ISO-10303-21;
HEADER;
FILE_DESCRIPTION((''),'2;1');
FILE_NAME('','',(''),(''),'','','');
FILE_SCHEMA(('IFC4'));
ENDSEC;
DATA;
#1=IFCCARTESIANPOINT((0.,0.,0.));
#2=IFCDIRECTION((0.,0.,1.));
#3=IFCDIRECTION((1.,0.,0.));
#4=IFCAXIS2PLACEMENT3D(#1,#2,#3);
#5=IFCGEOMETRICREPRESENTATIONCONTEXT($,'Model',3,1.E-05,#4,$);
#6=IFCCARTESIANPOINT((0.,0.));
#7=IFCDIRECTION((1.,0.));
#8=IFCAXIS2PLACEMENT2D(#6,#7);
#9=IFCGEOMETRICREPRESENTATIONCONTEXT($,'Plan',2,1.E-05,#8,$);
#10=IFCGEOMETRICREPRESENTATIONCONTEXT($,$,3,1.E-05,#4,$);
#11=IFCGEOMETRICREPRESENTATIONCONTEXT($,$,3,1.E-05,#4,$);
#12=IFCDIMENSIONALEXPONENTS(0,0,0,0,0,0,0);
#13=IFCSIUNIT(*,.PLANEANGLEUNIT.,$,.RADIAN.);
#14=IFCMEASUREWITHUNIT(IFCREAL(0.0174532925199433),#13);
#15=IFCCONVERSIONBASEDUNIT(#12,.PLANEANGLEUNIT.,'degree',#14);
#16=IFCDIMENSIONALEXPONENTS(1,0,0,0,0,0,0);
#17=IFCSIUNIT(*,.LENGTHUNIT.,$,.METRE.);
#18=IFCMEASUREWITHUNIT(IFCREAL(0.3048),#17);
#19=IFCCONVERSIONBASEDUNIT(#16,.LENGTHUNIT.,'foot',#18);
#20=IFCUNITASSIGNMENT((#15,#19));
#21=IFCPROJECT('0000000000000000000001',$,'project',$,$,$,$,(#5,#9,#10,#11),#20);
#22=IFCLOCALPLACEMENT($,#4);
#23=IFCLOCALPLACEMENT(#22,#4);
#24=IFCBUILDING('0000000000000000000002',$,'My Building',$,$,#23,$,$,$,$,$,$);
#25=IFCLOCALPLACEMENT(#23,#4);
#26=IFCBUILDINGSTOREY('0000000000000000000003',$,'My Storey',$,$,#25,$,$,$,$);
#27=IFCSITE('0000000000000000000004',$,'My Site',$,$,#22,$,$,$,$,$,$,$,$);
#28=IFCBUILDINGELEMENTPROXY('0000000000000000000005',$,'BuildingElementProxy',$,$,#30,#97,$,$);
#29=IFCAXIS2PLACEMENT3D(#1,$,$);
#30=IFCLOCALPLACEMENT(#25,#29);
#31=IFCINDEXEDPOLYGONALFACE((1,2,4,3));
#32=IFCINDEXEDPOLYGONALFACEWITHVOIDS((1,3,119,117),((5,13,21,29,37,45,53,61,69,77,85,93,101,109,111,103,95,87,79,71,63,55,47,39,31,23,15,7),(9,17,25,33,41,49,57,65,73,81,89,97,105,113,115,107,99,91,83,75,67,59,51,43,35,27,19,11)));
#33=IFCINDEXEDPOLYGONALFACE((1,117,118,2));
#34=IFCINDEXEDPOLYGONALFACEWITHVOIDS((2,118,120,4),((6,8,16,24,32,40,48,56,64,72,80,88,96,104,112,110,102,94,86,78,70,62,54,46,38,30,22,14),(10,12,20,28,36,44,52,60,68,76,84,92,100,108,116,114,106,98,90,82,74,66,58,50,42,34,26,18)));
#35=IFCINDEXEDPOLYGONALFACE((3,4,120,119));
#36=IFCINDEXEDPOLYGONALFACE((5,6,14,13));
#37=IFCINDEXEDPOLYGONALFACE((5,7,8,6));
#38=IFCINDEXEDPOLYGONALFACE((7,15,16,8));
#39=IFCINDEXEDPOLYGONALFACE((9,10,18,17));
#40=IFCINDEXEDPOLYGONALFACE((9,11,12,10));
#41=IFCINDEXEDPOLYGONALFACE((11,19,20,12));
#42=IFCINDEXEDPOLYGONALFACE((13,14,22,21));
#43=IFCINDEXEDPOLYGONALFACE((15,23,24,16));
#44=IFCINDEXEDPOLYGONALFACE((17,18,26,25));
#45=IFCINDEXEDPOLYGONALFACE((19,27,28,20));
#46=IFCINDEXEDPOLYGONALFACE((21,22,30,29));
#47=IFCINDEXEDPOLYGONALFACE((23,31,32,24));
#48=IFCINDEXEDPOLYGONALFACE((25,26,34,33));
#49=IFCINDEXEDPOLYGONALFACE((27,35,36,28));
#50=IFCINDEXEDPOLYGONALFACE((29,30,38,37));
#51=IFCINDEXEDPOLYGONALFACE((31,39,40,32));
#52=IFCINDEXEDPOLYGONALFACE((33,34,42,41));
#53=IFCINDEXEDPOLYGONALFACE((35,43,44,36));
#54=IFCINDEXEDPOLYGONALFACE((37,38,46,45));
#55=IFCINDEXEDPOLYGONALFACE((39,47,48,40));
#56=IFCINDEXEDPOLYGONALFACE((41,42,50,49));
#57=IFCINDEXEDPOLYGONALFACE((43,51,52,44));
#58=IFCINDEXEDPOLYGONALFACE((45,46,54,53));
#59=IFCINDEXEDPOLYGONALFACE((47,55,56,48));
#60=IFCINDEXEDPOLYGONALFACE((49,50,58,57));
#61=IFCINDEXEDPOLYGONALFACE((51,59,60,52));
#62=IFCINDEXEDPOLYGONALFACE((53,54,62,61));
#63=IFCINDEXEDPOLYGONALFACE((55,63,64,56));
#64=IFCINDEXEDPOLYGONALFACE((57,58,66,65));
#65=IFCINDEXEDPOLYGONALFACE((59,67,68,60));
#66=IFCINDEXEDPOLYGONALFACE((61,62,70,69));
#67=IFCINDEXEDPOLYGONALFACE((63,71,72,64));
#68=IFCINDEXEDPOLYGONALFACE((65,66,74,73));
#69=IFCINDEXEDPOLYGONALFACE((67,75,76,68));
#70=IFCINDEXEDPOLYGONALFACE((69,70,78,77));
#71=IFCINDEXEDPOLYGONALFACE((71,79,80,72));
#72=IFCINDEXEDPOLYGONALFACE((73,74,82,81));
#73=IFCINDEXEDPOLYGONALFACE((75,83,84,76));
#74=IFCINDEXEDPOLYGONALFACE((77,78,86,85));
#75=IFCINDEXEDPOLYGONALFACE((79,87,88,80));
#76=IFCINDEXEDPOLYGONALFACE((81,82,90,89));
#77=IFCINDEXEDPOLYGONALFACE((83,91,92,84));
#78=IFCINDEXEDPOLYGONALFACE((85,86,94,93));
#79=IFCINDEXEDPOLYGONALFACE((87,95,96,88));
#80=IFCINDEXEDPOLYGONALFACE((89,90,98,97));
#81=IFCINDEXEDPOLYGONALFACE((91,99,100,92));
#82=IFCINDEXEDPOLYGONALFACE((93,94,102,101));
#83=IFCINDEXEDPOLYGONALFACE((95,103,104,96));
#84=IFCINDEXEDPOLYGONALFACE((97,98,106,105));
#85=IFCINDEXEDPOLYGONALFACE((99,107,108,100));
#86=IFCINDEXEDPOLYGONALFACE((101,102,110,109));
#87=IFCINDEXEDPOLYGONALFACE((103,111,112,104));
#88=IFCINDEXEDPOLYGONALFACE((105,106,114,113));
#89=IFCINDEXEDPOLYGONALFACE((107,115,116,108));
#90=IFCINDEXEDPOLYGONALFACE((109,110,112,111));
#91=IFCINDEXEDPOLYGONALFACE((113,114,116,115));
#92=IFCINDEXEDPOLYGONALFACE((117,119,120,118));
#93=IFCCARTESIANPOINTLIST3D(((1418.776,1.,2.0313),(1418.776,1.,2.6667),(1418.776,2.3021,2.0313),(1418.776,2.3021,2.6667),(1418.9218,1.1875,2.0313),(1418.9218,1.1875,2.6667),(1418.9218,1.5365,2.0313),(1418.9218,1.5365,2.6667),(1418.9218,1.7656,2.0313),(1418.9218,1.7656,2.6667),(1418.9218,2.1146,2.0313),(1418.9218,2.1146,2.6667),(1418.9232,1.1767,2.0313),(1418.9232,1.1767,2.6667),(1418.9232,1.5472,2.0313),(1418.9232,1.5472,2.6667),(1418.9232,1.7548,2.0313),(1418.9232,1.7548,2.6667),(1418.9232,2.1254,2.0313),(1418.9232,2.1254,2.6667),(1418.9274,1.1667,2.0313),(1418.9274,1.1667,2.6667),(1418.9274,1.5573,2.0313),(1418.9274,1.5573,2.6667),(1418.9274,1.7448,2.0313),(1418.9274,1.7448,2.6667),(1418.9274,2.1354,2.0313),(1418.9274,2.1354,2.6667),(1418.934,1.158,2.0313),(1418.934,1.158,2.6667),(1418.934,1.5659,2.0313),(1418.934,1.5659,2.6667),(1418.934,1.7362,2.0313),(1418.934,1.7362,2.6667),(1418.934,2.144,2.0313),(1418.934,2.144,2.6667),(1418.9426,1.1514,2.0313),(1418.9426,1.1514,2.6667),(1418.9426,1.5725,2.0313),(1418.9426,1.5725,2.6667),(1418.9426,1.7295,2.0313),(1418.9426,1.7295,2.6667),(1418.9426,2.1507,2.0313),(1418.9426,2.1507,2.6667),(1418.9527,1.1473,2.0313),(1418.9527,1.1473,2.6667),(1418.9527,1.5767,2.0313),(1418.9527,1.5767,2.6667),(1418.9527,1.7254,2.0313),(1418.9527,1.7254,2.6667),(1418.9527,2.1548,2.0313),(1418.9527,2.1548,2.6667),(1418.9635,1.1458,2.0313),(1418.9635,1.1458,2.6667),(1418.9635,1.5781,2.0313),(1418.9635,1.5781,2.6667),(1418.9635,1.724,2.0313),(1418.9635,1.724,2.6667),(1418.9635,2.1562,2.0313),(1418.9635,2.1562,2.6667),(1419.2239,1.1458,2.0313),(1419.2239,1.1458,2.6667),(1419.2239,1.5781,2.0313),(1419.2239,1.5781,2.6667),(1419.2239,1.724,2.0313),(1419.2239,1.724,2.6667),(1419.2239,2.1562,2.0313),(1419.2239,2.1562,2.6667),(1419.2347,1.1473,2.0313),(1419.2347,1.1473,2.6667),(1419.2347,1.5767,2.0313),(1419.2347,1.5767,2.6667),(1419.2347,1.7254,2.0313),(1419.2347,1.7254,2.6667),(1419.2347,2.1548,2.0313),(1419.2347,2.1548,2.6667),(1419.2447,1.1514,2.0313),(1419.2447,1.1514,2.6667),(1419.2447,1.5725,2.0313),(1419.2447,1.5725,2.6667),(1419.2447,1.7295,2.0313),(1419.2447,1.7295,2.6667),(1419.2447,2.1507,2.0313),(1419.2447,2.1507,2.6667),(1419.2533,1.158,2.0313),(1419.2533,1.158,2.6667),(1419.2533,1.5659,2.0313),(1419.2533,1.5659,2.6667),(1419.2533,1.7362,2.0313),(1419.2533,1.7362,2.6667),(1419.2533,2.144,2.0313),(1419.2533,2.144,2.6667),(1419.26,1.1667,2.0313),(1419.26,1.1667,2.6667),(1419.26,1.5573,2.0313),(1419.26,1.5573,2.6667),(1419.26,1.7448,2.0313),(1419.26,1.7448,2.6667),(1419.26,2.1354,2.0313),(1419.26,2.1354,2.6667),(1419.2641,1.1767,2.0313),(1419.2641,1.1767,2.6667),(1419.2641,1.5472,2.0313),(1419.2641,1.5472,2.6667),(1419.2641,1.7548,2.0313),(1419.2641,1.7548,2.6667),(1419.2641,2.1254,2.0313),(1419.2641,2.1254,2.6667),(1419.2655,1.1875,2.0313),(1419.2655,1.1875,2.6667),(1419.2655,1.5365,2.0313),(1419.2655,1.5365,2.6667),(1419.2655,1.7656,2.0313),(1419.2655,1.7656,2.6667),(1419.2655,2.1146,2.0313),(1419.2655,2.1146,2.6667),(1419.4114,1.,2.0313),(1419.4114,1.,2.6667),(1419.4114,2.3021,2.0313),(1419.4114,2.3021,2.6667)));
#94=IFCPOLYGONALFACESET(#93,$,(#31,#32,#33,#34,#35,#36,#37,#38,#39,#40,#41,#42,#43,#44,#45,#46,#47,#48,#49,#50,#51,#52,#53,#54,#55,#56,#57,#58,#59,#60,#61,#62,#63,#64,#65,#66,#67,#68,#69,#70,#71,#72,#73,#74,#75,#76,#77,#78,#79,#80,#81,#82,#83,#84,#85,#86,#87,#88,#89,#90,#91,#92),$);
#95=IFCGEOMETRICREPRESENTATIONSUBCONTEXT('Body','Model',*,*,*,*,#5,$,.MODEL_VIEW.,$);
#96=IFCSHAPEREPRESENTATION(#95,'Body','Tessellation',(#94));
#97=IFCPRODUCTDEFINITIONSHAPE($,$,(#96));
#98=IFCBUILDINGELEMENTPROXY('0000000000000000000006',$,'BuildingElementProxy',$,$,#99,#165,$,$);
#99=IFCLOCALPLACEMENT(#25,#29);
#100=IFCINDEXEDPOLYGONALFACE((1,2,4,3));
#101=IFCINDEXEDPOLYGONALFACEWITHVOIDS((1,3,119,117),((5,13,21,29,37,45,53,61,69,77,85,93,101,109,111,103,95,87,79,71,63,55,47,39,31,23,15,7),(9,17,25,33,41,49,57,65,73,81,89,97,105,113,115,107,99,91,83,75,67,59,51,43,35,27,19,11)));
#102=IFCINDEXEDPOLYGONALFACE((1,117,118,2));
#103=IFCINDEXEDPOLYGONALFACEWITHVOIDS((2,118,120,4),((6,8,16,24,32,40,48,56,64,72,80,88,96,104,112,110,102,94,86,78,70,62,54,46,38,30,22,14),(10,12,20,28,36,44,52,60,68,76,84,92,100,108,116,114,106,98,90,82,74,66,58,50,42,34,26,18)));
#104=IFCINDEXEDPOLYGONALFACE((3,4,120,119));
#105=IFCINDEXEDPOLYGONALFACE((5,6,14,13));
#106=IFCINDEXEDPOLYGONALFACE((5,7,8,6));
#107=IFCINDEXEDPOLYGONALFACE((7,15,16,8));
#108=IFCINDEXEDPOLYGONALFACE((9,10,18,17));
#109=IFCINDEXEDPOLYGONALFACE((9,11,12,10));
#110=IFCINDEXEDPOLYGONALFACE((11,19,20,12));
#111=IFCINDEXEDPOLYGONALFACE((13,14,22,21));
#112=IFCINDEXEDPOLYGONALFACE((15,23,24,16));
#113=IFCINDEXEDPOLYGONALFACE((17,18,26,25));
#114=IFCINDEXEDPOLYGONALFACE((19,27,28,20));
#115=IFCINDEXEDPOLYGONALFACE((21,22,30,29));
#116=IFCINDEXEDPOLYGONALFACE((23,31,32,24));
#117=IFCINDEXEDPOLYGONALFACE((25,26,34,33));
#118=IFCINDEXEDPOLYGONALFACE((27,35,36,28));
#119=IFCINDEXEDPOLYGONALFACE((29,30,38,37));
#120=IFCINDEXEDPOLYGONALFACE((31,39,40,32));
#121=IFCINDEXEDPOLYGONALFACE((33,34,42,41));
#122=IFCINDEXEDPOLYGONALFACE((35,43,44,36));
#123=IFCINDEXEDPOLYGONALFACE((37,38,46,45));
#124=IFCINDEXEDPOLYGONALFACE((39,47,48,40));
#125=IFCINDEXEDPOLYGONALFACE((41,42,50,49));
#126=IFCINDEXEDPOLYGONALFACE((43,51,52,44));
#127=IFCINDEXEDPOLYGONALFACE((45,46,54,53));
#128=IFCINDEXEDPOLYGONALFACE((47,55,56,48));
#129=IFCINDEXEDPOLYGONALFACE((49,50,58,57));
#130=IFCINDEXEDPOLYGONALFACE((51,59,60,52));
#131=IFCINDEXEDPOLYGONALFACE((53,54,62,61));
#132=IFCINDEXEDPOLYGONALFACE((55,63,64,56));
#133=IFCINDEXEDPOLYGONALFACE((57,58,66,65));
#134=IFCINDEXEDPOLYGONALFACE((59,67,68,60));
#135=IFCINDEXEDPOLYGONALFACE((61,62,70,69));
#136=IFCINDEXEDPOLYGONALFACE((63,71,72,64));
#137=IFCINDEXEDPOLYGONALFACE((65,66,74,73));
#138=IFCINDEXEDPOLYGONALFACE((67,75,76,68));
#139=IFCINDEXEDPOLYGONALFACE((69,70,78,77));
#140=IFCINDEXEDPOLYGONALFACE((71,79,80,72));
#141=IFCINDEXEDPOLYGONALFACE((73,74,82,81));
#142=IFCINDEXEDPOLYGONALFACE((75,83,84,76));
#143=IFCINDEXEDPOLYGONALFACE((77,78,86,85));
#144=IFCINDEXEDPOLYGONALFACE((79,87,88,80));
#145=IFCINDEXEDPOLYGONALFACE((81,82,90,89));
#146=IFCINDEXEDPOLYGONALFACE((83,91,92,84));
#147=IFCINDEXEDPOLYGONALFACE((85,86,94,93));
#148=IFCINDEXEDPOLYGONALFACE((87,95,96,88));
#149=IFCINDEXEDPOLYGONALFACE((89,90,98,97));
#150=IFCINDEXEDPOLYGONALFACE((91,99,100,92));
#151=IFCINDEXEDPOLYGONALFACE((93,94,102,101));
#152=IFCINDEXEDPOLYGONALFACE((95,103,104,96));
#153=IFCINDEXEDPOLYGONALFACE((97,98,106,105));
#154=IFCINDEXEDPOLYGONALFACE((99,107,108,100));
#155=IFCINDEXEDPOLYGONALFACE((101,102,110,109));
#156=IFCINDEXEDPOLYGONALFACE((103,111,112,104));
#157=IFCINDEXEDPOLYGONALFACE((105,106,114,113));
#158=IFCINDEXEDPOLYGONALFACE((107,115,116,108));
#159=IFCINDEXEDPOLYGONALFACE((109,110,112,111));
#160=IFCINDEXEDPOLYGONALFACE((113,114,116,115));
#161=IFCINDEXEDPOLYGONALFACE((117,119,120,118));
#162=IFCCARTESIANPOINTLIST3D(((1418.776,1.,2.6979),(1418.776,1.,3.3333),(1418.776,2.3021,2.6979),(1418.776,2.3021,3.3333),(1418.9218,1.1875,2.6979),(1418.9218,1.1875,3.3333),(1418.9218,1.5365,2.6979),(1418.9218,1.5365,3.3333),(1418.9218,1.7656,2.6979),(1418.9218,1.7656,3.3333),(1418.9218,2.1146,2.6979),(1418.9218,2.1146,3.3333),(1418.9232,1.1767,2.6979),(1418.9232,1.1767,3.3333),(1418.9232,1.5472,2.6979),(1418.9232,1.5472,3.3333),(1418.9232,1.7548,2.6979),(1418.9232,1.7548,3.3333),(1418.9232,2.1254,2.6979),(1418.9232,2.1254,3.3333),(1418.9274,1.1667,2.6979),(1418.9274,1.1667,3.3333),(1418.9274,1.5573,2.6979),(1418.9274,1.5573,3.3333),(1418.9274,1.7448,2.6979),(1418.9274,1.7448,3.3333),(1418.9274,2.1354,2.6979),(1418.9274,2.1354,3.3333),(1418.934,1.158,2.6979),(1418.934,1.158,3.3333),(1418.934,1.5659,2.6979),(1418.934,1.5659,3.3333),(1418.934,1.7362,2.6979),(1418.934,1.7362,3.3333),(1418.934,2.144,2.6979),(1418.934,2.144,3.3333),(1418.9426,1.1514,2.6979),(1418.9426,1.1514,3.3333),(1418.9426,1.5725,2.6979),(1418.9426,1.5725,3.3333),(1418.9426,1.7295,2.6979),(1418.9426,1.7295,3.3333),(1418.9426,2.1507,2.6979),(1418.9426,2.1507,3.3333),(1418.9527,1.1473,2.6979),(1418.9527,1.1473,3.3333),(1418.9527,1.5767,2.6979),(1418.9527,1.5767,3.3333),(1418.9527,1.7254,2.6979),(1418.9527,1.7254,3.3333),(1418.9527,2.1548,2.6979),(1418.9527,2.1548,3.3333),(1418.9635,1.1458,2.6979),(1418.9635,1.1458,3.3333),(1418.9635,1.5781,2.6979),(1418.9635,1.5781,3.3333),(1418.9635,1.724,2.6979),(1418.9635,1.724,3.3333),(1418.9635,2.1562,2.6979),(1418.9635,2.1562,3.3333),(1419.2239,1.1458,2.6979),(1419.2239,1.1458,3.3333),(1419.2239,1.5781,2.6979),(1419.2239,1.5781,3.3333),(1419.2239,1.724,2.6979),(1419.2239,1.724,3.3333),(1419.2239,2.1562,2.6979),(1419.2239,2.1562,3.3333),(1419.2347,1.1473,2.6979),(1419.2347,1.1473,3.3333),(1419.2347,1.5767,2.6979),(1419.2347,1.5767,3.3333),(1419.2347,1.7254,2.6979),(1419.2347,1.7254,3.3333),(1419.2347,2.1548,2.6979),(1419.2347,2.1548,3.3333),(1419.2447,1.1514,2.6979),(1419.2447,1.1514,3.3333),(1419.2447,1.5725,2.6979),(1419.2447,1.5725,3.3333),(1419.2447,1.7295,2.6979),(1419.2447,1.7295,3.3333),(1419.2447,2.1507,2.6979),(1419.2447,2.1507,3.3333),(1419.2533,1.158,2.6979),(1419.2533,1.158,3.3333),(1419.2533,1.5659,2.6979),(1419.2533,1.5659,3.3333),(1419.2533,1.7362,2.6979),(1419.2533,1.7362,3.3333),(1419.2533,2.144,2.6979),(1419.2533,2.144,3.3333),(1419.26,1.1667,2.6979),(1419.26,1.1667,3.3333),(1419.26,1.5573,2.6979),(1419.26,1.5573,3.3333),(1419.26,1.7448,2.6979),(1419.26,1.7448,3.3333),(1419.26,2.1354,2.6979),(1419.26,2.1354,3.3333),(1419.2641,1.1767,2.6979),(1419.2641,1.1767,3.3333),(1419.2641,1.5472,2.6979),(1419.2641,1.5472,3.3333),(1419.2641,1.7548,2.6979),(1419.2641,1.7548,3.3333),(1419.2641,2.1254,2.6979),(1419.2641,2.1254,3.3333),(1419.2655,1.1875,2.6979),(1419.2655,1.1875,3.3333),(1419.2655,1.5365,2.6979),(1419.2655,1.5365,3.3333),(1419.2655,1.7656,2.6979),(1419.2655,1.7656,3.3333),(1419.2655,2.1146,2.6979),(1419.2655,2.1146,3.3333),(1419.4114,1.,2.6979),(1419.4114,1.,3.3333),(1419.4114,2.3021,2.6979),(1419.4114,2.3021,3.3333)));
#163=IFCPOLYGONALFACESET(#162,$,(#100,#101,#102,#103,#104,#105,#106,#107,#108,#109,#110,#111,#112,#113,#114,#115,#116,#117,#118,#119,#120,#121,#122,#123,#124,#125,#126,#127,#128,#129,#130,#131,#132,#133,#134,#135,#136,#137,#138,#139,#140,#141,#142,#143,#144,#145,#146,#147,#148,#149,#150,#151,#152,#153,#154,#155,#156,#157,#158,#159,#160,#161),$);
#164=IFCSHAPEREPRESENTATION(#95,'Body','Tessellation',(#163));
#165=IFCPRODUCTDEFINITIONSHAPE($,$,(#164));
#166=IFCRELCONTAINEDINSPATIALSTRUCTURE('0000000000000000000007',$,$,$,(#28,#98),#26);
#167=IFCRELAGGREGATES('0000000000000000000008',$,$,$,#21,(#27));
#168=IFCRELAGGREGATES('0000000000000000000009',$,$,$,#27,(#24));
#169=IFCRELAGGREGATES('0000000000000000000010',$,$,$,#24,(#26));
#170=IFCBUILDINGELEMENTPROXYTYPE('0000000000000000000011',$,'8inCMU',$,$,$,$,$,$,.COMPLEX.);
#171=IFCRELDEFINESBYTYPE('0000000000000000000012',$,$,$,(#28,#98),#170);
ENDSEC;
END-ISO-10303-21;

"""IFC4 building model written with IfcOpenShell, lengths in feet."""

from ifc_helpers import new_model, entity, si_unit, converted_unit, frame, origin_with_axes, origin_2d_with_axis, place, context, subcontext, project, spatial, line, indexed_curve, outline, extrude, source, transform, mapped, type_object, type_shapes, element, save


model = new_model("IFC4")

# Units and contexts
model_context_1 = context("Model", 3, precision=1e-05, world=origin_with_axes())
plan_context = context("Plan", 2, precision=1e-05, world=origin_2d_with_axis())
context_of_model_1 = context(None, 3, precision=1e-05, world=origin_with_axes())
context_of_model_2 = context(None, 3, precision=1e-05, world=origin_with_axes())
body_context_1 = subcontext(model_context_1, "Body", "Model", "MODEL_VIEW")
ifc_project = project(units=[converted_unit("PLANEANGLEUNIT", "degree", entity("IfcReal", 0.0174532925199433), si_unit("PLANEANGLEUNIT", "RADIAN"), dimensions=[0, 0, 0, 0, 0, 0, 0]), converted_unit("LENGTHUNIT", "foot", entity("IfcReal", 0.3048), si_unit("LENGTHUNIT", "METRE"), dimensions=[1, 0, 0, 0, 0, 0, 0])], contexts=[model_context_1, plan_context, context_of_model_1, context_of_model_2])

# Site, building, storey
site_placement = place(None, origin_with_axes())
site = spatial("IfcSite", under=ifc_project, at=site_placement, Name="My Site")
building_placement = place(site_placement, origin_with_axes())
building = spatial("IfcBuilding", under=site, at=building_placement, Name="My Building")
storey_placement = place(building_placement, origin_with_axes())
storey = spatial("IfcBuildingStorey", under=building, at=storey_placement, Name="My Storey")

# Building element proxies
building_element_proxy_type_1 = type_object("IfcBuildingElementProxyType", Name="8inCMU", PredefinedType="COMPLEX")
shared_shape_1 = source(origin_with_axes(), body_context_1, "Body", "SweptSolid", [
    extrude(outline(indexed_curve([(-0.3177, -0.651), (0.3177, -0.651), (0.3177, 0.651), (-0.3177, 0.651), (0.1719, -0.1146), (0.1719, -0.4635), (0.1705, -0.4743), (0.1663, -0.4844), (0.1597, -0.493), (0.151, -0.4996), (0.141, -0.5038), (0.1302, -0.5052), (-0.1302, -0.5052), (-0.141, -0.5038), (-0.151, -0.4996), (-0.1597, -0.493), (-0.1663, -0.4844), (-0.1705, -0.4743), (-0.1719, -0.4635), (-0.1719, -0.1146), (-0.1705, -0.1038), (-0.1663, -0.0938), (-0.1597, -0.0851), (-0.151, -0.0785), (-0.141, -0.0743), (-0.1302, -0.0729), (0.1302, -0.0729), (0.141, -0.0743), (0.151, -0.0785), (0.1597, -0.0851), (0.1663, -0.0938), (0.1705, -0.1038), (0.151, 0.0785), (0.141, 0.0743), (0.1302, 0.0729), (-0.1302, 0.0729), (-0.141, 0.0743), (-0.151, 0.0785), (-0.1597, 0.0851), (-0.1663, 0.0937), (-0.1705, 0.1038), (-0.1719, 0.1146), (-0.1719, 0.4635), (-0.1705, 0.4743), (-0.1663, 0.4844), (-0.1597, 0.493), (-0.151, 0.4996), (-0.141, 0.5038), (-0.1302, 0.5052), (0.1302, 0.5052), (0.141, 0.5038), (0.151, 0.4996), (0.1597, 0.493), (0.1663, 0.4844), (0.1705, 0.4743), (0.1719, 0.4635), (0.1719, 0.1146), (0.1705, 0.1038), (0.1663, 0.0937), (0.1597, 0.0851)], segments=[line(4, 3), line(3, 2), line(2, 1), line(1, 4)], self_intersect=False), holes=[indexed_curve([(-0.3177, -0.651), (0.3177, -0.651), (0.3177, 0.651), (-0.3177, 0.651), (0.1719, -0.1146), (0.1719, -0.4635), (0.1705, -0.4743), (0.1663, -0.4844), (0.1597, -0.493), (0.151, -0.4996), (0.141, -0.5038), (0.1302, -0.5052), (-0.1302, -0.5052), (-0.141, -0.5038), (-0.151, -0.4996), (-0.1597, -0.493), (-0.1663, -0.4844), (-0.1705, -0.4743), (-0.1719, -0.4635), (-0.1719, -0.1146), (-0.1705, -0.1038), (-0.1663, -0.0938), (-0.1597, -0.0851), (-0.151, -0.0785), (-0.141, -0.0743), (-0.1302, -0.0729), (0.1302, -0.0729), (0.141, -0.0743), (0.151, -0.0785), (0.1597, -0.0851), (0.1663, -0.0938), (0.1705, -0.1038), (0.151, 0.0785), (0.141, 0.0743), (0.1302, 0.0729), (-0.1302, 0.0729), (-0.141, 0.0743), (-0.151, 0.0785), (-0.1597, 0.0851), (-0.1663, 0.0937), (-0.1705, 0.1038), (-0.1719, 0.1146), (-0.1719, 0.4635), (-0.1705, 0.4743), (-0.1663, 0.4844), (-0.1597, 0.493), (-0.151, 0.4996), (-0.141, 0.5038), (-0.1302, 0.5052), (0.1302, 0.5052), (0.141, 0.5038), (0.151, 0.4996), (0.1597, 0.493), (0.1663, 0.4844), (0.1705, 0.4743), (0.1719, 0.4635), (0.1719, 0.1146), (0.1705, 0.1038), (0.1663, 0.0937), (0.1597, 0.0851)], segments=[line(20, 19), line(19, 18), line(18, 17), line(17, 16), line(16, 15), line(15, 14), line(14, 13), line(13, 12), line(12, 11), line(11, 10), line(10, 9), line(9, 8), line(8, 7), line(7, 6), line(6, 5), line(5, 32), line(32, 31), line(31, 30), line(30, 29), line(29, 28), line(28, 27), line(27, 26), line(26, 25), line(25, 24), line(24, 23), line(23, 22), line(22, 21), line(21, 20)], self_intersect=False), indexed_curve([(-0.3177, -0.651), (0.3177, -0.651), (0.3177, 0.651), (-0.3177, 0.651), (0.1719, -0.1146), (0.1719, -0.4635), (0.1705, -0.4743), (0.1663, -0.4844), (0.1597, -0.493), (0.151, -0.4996), (0.141, -0.5038), (0.1302, -0.5052), (-0.1302, -0.5052), (-0.141, -0.5038), (-0.151, -0.4996), (-0.1597, -0.493), (-0.1663, -0.4844), (-0.1705, -0.4743), (-0.1719, -0.4635), (-0.1719, -0.1146), (-0.1705, -0.1038), (-0.1663, -0.0938), (-0.1597, -0.0851), (-0.151, -0.0785), (-0.141, -0.0743), (-0.1302, -0.0729), (0.1302, -0.0729), (0.141, -0.0743), (0.151, -0.0785), (0.1597, -0.0851), (0.1663, -0.0938), (0.1705, -0.1038), (0.151, 0.0785), (0.141, 0.0743), (0.1302, 0.0729), (-0.1302, 0.0729), (-0.141, 0.0743), (-0.151, 0.0785), (-0.1597, 0.0851), (-0.1663, 0.0937), (-0.1705, 0.1038), (-0.1719, 0.1146), (-0.1719, 0.4635), (-0.1705, 0.4743), (-0.1663, 0.4844), (-0.1597, 0.493), (-0.151, 0.4996), (-0.141, 0.5038), (-0.1302, 0.5052), (0.1302, 0.5052), (0.141, 0.5038), (0.151, 0.4996), (0.1597, 0.493), (0.1663, 0.4844), (0.1705, 0.4743), (0.1719, 0.4635), (0.1719, 0.1146), (0.1705, 0.1038), (0.1663, 0.0937), (0.1597, 0.0851)], segments=[line(44, 43), line(43, 42), line(42, 41), line(41, 40), line(40, 39), line(39, 38), line(38, 37), line(37, 36), line(36, 35), line(35, 34), line(34, 33), line(33, 60), line(60, 59), line(59, 58), line(58, 57), line(57, 56), line(56, 55), line(55, 54), line(54, 53), line(53, 52), line(52, 51), line(51, 50), line(50, 49), line(49, 48), line(48, 47), line(47, 46), line(46, 45), line(45, 44)], self_intersect=False)]), frame((-0.651, 0.0, 0.0), z_axis=(0.0, 0.0, 1.0), x_axis=(0.0, -1.0, 0.0)), (0.0, 0.0, 1.0), 0.6354),
])
type_shapes(building_element_proxy_type_1, [shared_shape_1])
for number, where, z_axis, x_axis, name in (
    (1, (1419.0936, 2.3021, 2.0313), (0.0, 0.0, 1.0), (0.0, 1.0, 0.0), "BuildingElementProxy"),
    (2, (1419.0936, 2.3021, 2.6979), (0.0, 0.0, 1.0), (0.0, 1.0, 0.0), "BuildingElementProxy"),
):
    element("IfcBuildingElementProxy", number, at=place(storey_placement, frame(where, z_axis=z_axis, x_axis=x_axis)), inside=storey, type_object=building_element_proxy_type_1, Name=name, context=body_context_1, shape_type="MappedRepresentation", body=[
        mapped(shared_shape_1, transform((0.0, 0.0, 0.0), x_axis=(1.0, 0.0, 0.0), y_axis=(0.0, 1.0, 0.0), z_axis=(0.0, 0.0, 1.0), scale=1.0)),
    ])

save(model, "model.ifc")
